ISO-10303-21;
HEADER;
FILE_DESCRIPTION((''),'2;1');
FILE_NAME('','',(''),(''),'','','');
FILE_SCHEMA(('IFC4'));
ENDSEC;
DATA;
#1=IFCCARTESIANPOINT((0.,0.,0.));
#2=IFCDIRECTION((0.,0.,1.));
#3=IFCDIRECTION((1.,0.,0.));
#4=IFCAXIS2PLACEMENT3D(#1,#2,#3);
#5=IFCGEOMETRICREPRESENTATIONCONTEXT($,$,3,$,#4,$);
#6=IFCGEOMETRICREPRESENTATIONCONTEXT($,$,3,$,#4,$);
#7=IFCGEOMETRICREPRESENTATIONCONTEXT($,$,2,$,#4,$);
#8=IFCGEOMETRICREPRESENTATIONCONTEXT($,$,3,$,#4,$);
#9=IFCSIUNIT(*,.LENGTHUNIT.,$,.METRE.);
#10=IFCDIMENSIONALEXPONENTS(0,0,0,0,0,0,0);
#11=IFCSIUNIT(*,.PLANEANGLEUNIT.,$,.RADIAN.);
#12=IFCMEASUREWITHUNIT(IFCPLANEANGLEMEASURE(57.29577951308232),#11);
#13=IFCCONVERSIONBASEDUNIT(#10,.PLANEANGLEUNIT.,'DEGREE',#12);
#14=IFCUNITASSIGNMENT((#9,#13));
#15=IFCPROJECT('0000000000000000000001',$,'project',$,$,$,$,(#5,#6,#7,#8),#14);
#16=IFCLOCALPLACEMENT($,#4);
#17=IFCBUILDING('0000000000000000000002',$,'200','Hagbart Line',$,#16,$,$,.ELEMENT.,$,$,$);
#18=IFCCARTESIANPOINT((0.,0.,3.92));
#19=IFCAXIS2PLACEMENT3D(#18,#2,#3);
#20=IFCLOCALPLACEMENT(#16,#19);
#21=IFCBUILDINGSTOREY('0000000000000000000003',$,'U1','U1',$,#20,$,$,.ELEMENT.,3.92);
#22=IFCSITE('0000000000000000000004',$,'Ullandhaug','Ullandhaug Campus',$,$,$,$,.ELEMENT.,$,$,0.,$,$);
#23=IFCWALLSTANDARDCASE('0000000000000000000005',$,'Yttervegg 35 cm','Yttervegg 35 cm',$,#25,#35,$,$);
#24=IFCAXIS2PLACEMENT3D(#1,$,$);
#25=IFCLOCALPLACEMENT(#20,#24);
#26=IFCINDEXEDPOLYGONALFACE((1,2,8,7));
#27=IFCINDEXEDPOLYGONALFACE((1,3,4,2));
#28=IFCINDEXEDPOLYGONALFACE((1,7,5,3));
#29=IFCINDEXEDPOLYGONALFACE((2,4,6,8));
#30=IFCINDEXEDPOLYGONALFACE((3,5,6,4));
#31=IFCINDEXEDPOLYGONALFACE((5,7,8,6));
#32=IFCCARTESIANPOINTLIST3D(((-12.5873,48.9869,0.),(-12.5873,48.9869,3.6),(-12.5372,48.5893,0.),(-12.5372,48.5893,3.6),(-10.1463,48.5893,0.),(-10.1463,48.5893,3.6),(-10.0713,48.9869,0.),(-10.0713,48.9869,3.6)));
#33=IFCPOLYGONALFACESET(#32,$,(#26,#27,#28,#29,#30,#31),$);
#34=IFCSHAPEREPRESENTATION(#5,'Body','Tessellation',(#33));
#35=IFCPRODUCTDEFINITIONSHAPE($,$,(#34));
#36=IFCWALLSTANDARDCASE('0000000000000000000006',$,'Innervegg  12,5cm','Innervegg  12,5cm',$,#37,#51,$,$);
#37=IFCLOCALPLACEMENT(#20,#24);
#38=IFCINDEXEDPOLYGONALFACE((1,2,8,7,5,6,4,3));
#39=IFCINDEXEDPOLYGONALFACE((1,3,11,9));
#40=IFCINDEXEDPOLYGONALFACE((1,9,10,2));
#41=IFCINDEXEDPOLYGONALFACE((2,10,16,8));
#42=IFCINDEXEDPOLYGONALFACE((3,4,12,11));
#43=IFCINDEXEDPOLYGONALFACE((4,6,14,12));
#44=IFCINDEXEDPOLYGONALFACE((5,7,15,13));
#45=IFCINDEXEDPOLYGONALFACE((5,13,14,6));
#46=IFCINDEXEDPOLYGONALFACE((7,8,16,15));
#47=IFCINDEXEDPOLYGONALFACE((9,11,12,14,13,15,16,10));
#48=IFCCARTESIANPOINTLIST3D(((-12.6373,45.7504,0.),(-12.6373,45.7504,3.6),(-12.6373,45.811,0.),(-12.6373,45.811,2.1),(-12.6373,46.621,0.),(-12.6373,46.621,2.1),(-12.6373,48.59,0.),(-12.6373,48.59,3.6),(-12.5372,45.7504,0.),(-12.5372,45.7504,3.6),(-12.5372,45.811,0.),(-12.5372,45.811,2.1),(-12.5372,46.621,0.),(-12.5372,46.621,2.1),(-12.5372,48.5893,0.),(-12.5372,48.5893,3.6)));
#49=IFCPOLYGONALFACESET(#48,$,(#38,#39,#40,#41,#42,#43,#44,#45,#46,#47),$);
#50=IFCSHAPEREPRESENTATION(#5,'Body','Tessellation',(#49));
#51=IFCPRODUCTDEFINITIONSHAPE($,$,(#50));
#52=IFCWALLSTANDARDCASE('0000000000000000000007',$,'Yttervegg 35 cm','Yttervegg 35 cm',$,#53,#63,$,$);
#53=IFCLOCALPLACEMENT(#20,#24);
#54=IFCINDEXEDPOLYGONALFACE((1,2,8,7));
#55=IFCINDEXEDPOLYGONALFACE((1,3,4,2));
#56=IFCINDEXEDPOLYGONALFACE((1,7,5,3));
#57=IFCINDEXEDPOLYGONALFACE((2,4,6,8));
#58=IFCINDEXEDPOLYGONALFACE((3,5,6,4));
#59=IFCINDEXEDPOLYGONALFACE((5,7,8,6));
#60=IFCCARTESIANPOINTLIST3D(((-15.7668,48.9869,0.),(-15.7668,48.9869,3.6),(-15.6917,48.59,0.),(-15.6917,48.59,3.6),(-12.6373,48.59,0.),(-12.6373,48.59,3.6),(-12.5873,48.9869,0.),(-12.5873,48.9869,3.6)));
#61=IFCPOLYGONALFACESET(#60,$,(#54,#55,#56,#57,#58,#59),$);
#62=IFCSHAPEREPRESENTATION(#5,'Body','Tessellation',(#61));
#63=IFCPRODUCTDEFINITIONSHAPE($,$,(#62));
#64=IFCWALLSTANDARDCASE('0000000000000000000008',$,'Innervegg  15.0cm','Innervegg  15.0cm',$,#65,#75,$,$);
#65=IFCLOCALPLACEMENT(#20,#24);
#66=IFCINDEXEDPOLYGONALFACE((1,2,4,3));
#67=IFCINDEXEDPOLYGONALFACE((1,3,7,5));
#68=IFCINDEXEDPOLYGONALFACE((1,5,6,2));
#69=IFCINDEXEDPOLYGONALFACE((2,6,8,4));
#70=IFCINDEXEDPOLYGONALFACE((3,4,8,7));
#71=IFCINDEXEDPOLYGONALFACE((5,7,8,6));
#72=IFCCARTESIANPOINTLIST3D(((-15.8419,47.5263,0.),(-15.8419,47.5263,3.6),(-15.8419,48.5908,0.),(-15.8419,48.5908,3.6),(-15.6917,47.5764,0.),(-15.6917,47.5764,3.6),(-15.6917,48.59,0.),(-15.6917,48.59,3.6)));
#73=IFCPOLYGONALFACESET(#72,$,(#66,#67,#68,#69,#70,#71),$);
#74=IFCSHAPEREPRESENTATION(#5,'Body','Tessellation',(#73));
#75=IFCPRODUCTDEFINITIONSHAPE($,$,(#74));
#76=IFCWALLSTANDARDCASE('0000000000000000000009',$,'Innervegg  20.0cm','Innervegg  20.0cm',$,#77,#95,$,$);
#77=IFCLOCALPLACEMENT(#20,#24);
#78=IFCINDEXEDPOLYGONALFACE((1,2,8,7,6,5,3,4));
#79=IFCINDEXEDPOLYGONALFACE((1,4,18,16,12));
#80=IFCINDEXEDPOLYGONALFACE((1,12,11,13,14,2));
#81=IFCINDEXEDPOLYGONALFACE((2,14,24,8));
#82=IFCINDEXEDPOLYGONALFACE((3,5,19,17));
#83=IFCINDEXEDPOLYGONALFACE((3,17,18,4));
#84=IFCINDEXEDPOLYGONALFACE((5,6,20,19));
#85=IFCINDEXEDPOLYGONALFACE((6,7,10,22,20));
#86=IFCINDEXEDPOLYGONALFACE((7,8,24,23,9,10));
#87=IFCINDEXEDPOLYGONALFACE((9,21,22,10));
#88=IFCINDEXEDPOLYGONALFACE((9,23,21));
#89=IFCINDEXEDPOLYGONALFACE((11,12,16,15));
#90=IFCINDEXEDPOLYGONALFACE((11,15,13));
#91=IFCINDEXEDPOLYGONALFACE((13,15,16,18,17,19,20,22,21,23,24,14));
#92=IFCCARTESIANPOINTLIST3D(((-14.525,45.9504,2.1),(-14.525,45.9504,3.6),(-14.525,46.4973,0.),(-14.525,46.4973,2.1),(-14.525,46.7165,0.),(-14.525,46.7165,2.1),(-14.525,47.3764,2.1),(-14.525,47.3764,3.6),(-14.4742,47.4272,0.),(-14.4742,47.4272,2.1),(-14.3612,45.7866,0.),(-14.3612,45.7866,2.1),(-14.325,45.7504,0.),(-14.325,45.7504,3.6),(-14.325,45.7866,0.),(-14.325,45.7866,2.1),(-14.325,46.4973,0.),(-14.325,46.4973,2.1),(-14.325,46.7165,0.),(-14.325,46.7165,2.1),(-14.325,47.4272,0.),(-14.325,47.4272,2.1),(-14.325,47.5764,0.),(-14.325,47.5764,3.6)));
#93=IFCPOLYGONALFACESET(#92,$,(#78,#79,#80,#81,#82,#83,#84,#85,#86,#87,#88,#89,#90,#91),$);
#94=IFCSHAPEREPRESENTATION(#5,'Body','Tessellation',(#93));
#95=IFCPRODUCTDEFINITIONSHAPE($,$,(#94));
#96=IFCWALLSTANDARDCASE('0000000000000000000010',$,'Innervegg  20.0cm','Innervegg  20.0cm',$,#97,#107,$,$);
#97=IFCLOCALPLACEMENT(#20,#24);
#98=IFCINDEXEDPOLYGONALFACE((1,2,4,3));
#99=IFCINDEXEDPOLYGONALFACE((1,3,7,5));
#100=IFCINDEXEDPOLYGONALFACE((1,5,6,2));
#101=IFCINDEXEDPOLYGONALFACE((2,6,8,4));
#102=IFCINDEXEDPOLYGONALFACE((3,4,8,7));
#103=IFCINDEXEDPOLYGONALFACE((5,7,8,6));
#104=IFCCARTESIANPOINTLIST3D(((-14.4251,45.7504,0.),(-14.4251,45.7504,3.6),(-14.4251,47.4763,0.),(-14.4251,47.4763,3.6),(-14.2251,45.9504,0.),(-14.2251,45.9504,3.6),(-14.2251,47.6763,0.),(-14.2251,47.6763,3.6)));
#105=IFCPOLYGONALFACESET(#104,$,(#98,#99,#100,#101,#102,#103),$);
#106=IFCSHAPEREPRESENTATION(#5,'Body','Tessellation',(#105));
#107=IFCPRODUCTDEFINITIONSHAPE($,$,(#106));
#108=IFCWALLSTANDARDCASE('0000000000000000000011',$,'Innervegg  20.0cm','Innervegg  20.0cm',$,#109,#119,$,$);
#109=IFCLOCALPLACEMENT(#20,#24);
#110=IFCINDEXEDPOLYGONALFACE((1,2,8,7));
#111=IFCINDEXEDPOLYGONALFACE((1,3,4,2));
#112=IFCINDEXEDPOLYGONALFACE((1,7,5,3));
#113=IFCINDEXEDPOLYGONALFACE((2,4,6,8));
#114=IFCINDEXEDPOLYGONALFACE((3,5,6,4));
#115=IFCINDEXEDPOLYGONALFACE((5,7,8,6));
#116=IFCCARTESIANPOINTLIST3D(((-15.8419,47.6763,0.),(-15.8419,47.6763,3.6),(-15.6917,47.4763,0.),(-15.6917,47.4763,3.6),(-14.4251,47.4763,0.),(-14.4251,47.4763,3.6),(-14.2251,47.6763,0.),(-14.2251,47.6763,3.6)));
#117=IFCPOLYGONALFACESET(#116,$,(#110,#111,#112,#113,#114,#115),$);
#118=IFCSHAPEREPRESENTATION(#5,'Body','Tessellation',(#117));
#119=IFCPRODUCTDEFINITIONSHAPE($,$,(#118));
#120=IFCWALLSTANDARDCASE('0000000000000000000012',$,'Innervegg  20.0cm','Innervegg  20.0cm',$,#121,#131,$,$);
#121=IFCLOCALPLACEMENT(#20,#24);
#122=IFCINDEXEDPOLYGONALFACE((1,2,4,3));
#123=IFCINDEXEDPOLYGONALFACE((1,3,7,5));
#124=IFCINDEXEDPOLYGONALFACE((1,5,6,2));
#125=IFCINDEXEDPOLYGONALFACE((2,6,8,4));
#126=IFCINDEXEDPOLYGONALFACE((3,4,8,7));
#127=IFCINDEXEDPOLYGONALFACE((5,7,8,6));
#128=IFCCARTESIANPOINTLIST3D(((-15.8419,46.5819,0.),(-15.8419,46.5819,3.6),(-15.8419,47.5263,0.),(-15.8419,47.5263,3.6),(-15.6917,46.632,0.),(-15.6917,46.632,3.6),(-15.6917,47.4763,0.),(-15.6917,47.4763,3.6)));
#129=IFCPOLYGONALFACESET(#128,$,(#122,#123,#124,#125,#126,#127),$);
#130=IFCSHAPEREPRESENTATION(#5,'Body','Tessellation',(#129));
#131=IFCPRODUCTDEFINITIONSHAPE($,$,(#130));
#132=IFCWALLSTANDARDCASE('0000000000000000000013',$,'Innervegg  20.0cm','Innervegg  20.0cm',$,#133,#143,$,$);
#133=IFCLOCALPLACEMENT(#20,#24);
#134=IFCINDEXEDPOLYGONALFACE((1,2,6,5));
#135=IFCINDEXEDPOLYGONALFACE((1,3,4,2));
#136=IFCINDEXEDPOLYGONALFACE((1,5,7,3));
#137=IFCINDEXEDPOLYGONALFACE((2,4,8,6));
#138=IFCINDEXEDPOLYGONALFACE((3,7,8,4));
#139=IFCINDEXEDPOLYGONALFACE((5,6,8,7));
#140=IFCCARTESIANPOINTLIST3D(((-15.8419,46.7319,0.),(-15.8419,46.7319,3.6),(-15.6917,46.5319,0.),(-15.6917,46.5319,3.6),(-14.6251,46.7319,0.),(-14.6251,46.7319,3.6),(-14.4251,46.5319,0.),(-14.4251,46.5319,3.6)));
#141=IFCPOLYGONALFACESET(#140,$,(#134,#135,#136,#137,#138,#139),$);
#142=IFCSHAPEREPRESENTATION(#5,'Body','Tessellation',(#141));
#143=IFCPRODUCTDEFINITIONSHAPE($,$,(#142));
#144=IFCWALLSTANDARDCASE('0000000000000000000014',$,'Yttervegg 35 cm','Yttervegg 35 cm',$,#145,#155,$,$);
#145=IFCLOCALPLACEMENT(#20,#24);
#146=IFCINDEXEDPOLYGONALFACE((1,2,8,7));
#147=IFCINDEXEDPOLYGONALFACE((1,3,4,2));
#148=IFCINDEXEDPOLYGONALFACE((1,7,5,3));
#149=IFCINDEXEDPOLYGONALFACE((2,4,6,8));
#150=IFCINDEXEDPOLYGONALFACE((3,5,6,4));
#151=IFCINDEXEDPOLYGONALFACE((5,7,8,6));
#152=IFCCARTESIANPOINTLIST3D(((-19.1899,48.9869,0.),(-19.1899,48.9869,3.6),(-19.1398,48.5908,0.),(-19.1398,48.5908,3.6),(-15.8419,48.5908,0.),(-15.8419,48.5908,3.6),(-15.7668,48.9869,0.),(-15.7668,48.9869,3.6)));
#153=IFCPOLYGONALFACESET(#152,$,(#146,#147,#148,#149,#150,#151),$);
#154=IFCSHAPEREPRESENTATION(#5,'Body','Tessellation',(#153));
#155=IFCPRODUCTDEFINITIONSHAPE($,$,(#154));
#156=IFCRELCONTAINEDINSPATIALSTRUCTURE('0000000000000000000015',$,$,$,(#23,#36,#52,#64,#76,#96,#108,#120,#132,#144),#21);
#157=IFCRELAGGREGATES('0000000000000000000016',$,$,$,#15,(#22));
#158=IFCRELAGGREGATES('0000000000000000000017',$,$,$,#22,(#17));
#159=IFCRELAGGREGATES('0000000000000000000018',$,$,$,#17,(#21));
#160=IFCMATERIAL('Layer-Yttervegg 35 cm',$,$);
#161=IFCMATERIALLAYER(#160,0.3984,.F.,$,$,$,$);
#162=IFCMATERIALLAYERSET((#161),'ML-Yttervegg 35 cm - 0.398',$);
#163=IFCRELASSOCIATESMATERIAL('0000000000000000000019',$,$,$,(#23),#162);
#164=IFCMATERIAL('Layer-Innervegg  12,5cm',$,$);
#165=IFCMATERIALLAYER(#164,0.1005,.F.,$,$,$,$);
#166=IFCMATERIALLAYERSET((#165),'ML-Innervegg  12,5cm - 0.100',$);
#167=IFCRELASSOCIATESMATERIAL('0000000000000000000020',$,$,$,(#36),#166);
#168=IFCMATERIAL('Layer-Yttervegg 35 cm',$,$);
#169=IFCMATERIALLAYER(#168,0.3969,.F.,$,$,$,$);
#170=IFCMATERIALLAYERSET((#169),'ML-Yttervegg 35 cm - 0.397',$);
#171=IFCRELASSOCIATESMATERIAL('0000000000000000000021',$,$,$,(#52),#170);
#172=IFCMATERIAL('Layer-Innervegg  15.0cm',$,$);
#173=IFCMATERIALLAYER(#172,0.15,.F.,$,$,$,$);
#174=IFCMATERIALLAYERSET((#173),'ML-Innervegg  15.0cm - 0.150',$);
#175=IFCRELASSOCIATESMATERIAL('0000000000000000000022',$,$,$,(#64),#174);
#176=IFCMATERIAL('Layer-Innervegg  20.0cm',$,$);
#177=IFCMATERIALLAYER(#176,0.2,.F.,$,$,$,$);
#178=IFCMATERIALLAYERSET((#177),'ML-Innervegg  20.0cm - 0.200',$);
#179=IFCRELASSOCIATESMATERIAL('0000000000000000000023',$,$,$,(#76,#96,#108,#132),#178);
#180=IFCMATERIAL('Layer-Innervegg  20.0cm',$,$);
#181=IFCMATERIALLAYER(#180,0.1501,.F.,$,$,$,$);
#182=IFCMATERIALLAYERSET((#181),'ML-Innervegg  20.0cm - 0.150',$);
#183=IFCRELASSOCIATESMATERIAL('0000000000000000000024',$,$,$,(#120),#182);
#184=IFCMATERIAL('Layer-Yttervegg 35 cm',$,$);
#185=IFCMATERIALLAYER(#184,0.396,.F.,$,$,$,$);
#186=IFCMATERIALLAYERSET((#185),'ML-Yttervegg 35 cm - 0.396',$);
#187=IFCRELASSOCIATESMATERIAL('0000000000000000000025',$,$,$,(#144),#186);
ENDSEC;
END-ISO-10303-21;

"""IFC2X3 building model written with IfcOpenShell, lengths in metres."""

from ifc_helpers import new_model, entity, si_unit, converted_unit, frame, origin_with_axes, place, context, project, spatial, polyline, outline, extrude, material, layer, layer_set, layer_usage, element, save


model = new_model("IFC2X3")

# Units and contexts
context_of_model_1 = context(None, 3, world=origin_with_axes())
context_of_model_2 = context(None, 3, world=origin_with_axes())
context_of_model_3 = context(None, 2, world=origin_with_axes())
context_of_model_4 = context(None, 3, world=origin_with_axes())
ifc_project = project(units=[si_unit("LENGTHUNIT", "METRE"), converted_unit("PLANEANGLEUNIT", "DEGREE", entity("IfcPlaneAngleMeasure", 57.29577951308232), si_unit("PLANEANGLEUNIT", "RADIAN"), dimensions=[0, 0, 0, 0, 0, 0, 0])], contexts=[context_of_model_1, context_of_model_2, context_of_model_3, context_of_model_4])

# Site, building, storey
site = spatial("IfcSite", under=ifc_project, Name="Ullandhaug", Description="Ullandhaug Campus", CompositionType="ELEMENT", RefElevation=0.0)
building_placement = place(None, origin_with_axes())
building = spatial("IfcBuilding", under=site, at=building_placement, Name="200", Description="Hagbart Line", CompositionType="ELEMENT")
storey_placement = place(building_placement, frame((0.0, 0.0, 3.92), z_axis=(0.0, 0.0, 1.0), x_axis=(1.0, 0.0, 0.0)))
storey = spatial("IfcBuildingStorey", under=building, at=storey_placement, Name="U1", Description="U1", CompositionType="ELEMENT", Elevation=3.92)

# Shared definitions
ifc_material_1 = material(Name="Layer-Innervegg  15.0cm")
ifc_layer_1 = layer(ifc_material_1, 0.15, ventilated=False)
ifc_layer_set_1 = layer_set([ifc_layer_1], Name="ML-Innervegg  15.0cm - 0.150")
ifc_layer_usage_1 = layer_usage(ifc_layer_set_1, "AXIS2", "POSITIVE", 0.0)
ifc_material_2 = material(Name="Layer-Innervegg  20.0cm")
ifc_layer_2 = layer(ifc_material_2, 0.2, ventilated=False)
ifc_layer_set_2 = layer_set([ifc_layer_2], Name="ML-Innervegg  20.0cm - 0.200")
ifc_layer_usage_2 = layer_usage(ifc_layer_set_2, "AXIS2", "POSITIVE", 0.0)

# Wall
ifc_material_3 = material(Name="Layer-Yttervegg 35 cm")
ifc_layer_3 = layer(ifc_material_3, 0.3984, ventilated=False)
ifc_layer_set_3 = layer_set([ifc_layer_3], Name="ML-Yttervegg 35 cm - 0.398")
ifc_layer_usage_3 = layer_usage(ifc_layer_set_3, "AXIS2", "POSITIVE", 0.0)
wall_1_placement = place(storey_placement, frame((-10.0713, 48.9869, 0.0), z_axis=(0.0, 0.0, 1.0), x_axis=(-1.0, 0.0, 0.0)))
element("IfcWallStandardCase", 1, at=wall_1_placement, inside=storey, material=ifc_layer_usage_3, Name="Yttervegg 35 cm", Description="Yttervegg 35 cm", context=context_of_model_1, shape_type="SweptSolid", body=[
    extrude(outline(polyline([(0.0, 0.0), (2.516, 0.0), (2.466, 0.3976), (0.0751, 0.3976), (0.0, 0.0)])), frame((0.0, 0.0, 0.0), z_axis=(0.0, 0.0, 1.0), x_axis=(1.0, 0.0, 0.0)), (0.0, 0.0, 1.0), 3.6),
])

# Wall, opening
ifc_material_4 = material(Name="Layer-Innervegg  12,5cm")
ifc_layer_4 = layer(ifc_material_4, 0.1005, ventilated=False)
ifc_layer_set_4 = layer_set([ifc_layer_4], Name="ML-Innervegg  12,5cm - 0.100")
ifc_layer_usage_4 = layer_usage(ifc_layer_set_4, "AXIS2", "POSITIVE", 0.0)
wall_2_placement = place(storey_placement, frame((-12.6373, 48.59, 0.0), z_axis=(0.0, 0.0, 1.0), x_axis=(0.0, -1.0, 0.0)))
wall_2 = element("IfcWallStandardCase", 2, at=wall_2_placement, inside=storey, material=ifc_layer_usage_4, Name="Innervegg  12,5cm", Description="Innervegg  12,5cm", context=context_of_model_1, shape_type="SweptSolid", body=[
    extrude(outline(polyline([(0.0, 0.0), (2.8395, 0.0), (2.8395, 0.1001), (0.0007, 0.1001), (0.0, 0.0)])), frame((0.0, 0.0, 0.0), z_axis=(0.0, 0.0, 1.0), x_axis=(1.0, 0.0, 0.0)), (0.0, 0.0, 1.0), 3.6),
])
opening_1_placement = place(wall_2_placement, frame((1.969, 0.1001, 0.0), z_axis=(0.0, 0.0, 1.0), x_axis=(1.0, 0.0, 0.0)))
element("IfcOpeningElement", 3, at=opening_1_placement, cuts=wall_2, context=context_of_model_1, shape_type="SweptSolid", body=[
    extrude(outline(polyline([(0.0, 0.0), (2.1, 0.0), (2.1, 0.81), (0.0, 0.81), (0.0, 0.0)])), frame((0.0, 0.0, 0.0), z_axis=(0.0, 1.0, 0.0), x_axis=(0.0, 0.0, 1.0)), (0.0, 0.0, -1.0), 0.1001),
])

# Walls
ifc_material_5 = material(Name="Layer-Yttervegg 35 cm")
ifc_layer_5 = layer(ifc_material_5, 0.3969, ventilated=False)
ifc_layer_set_5 = layer_set([ifc_layer_5], Name="ML-Yttervegg 35 cm - 0.397")
ifc_layer_usage_5 = layer_usage(ifc_layer_set_5, "AXIS2", "POSITIVE", 0.0)
wall_3_placement = place(storey_placement, frame((-12.5873, 48.9869, 0.0), z_axis=(0.0, 0.0, 1.0), x_axis=(-1.0, 0.0, 0.0)))
element("IfcWallStandardCase", 4, at=wall_3_placement, inside=storey, material=ifc_layer_usage_5, Name="Yttervegg 35 cm", Description="Yttervegg 35 cm", context=context_of_model_1, shape_type="SweptSolid", body=[
    extrude(outline(polyline([(0.0, 0.0), (3.1795, 0.0), (3.1044, 0.3969), (0.05, 0.3969), (0.0, 0.0)])), frame((0.0, 0.0, 0.0), z_axis=(0.0, 0.0, 1.0), x_axis=(1.0, 0.0, 0.0)), (0.0, 0.0, 1.0), 3.6),
])
wall_4_placement = place(storey_placement, frame((-15.8419, 48.5908, 0.0), z_axis=(0.0, 0.0, 1.0), x_axis=(0.0, -1.0, 0.0)))
element("IfcWallStandardCase", 5, at=wall_4_placement, inside=storey, material=ifc_layer_usage_1, Name="Innervegg  15.0cm", Description="Innervegg  15.0cm", context=context_of_model_1, shape_type="SweptSolid", body=[
    extrude(outline(polyline([(0.0, 0.0), (1.0645, 0.0), (1.0144, 0.1501), (0.0009, 0.1501), (0.0, 0.0)])), frame((0.0, 0.0, 0.0), z_axis=(0.0, 0.0, 1.0), x_axis=(1.0, 0.0, 0.0)), (0.0, 0.0, 1.0), 3.6),
])

# Wall, openings
wall_5_placement = place(storey_placement, frame((-14.525, 47.3764, 0.0), z_axis=(0.0, 0.0, 1.0), x_axis=(0.0, -1.0, 0.0)))
wall_5 = element("IfcWallStandardCase", 6, at=wall_5_placement, inside=storey, material=ifc_layer_usage_2, Name="Innervegg  20.0cm", Description="Innervegg  20.0cm", context=context_of_model_1, shape_type="SweptSolid", body=[
    extrude(outline(polyline([(0.0, 0.0), (1.426, 0.0), (1.626, 0.2), (-0.2, 0.2), (0.0, 0.0)])), frame((0.0, 0.0, 0.0), z_axis=(0.0, 0.0, 1.0), x_axis=(1.0, 0.0, 0.0)), (0.0, 0.0, 1.0), 3.6),
])
opening_2_placement = place(wall_5_placement, frame((-0.0509, 0.2, 0.0), z_axis=(0.0, 0.0, 1.0), x_axis=(1.0, 0.0, 0.0)))
element("IfcOpeningElement", 7, at=opening_2_placement, cuts=wall_5, context=context_of_model_1, shape_type="SweptSolid", body=[
    extrude(outline(polyline([(0.0, 0.0), (2.1, 0.0), (2.1, 0.7107), (0.0, 0.7107), (0.0, 0.0)])), frame((0.0, 0.0, 0.0), z_axis=(0.0, 1.0, 0.0), x_axis=(0.0, 0.0, 1.0)), (0.0, 0.0, -1.0), 0.2),
])
opening_3_placement = place(wall_5_placement, frame((0.8791, 0.2, 0.0), z_axis=(0.0, 0.0, 1.0), x_axis=(1.0, 0.0, 0.0)))
element("IfcOpeningElement", 8, at=opening_3_placement, cuts=wall_5, context=context_of_model_1, shape_type="SweptSolid", body=[
    extrude(outline(polyline([(0.0, 0.0), (2.1, 0.0), (2.1, 0.7107), (0.0, 0.7107), (0.0, 0.0)])), frame((0.0, 0.0, 0.0), z_axis=(0.0, 1.0, 0.0), x_axis=(0.0, 0.0, 1.0)), (0.0, 0.0, -1.0), 0.2),
])

# Walls
wall_6_placement = place(storey_placement, frame((-14.2251, 45.9504, 0.0), z_axis=(0.0, 0.0, 1.0), x_axis=(0.0, 1.0, 0.0)))
element("IfcWallStandardCase", 9, at=wall_6_placement, inside=storey, material=ifc_layer_usage_2, Name="Innervegg  20.0cm", Description="Innervegg  20.0cm", context=context_of_model_1, shape_type="SweptSolid", body=[
    extrude(outline(polyline([(0.0, 0.0), (1.7259, 0.0), (1.5259, 0.2), (-0.2, 0.2), (0.0, 0.0)])), frame((0.0, 0.0, 0.0), z_axis=(0.0, 0.0, 1.0), x_axis=(1.0, 0.0, 0.0)), (0.0, 0.0, 1.0), 3.6),
])
wall_7_placement = place(storey_placement, frame((-14.2251, 47.6763, 0.0), z_axis=(0.0, 0.0, 1.0), x_axis=(-1.0, 0.0, 0.0)))
element("IfcWallStandardCase", 10, at=wall_7_placement, inside=storey, material=ifc_layer_usage_2, Name="Innervegg  20.0cm", Description="Innervegg  20.0cm", context=context_of_model_1, shape_type="SweptSolid", body=[
    extrude(outline(polyline([(0.0, 0.0), (1.6168, 0.0), (1.4666, 0.2), (0.2, 0.2), (0.0, 0.0)])), frame((0.0, 0.0, 0.0), z_axis=(0.0, 0.0, 1.0), x_axis=(1.0, 0.0, 0.0)), (0.0, 0.0, 1.0), 3.6),
])
ifc_material_6 = material(Name="Layer-Innervegg  20.0cm")
ifc_layer_6 = layer(ifc_material_6, 0.1501, ventilated=False)
ifc_layer_set_6 = layer_set([ifc_layer_6], Name="ML-Innervegg  20.0cm - 0.150")
ifc_layer_usage_6 = layer_usage(ifc_layer_set_6, "AXIS2", "POSITIVE", 0.0)
wall_8_placement = place(storey_placement, frame((-15.8419, 47.5263, 0.0), z_axis=(0.0, 0.0, 1.0), x_axis=(0.0, -1.0, 0.0)))
element("IfcWallStandardCase", 11, at=wall_8_placement, inside=storey, material=ifc_layer_usage_6, Name="Innervegg  20.0cm", Description="Innervegg  20.0cm", context=context_of_model_1, shape_type="SweptSolid", body=[
    extrude(outline(polyline([(0.0, 0.0), (0.9444, 0.0), (0.8943, 0.1501), (0.05, 0.1501), (0.0, 0.0)])), frame((0.0, 0.0, 0.0), z_axis=(0.0, 0.0, 1.0), x_axis=(1.0, 0.0, 0.0)), (0.0, 0.0, 1.0), 3.6),
])
wall_9_placement = place(storey_placement, frame((-14.6251, 46.7319, 0.0), z_axis=(0.0, 0.0, 1.0), x_axis=(-1.0, 0.0, 0.0)))
element("IfcWallStandardCase", 12, at=wall_9_placement, inside=storey, material=ifc_layer_usage_2, Name="Innervegg  20.0cm", Description="Innervegg  20.0cm", context=context_of_model_1, shape_type="SweptSolid", body=[
    extrude(outline(polyline([(0.0, 0.0), (1.2168, 0.0), (1.0666, 0.2), (-0.2, 0.2), (0.0, 0.0)])), frame((0.0, 0.0, 0.0), z_axis=(0.0, 0.0, 1.0), x_axis=(1.0, 0.0, 0.0)), (0.0, 0.0, 1.0), 3.6),
])
ifc_material_7 = material(Name="Layer-Yttervegg 35 cm")
ifc_layer_7 = layer(ifc_material_7, 0.396, ventilated=False)
ifc_layer_set_7 = layer_set([ifc_layer_7], Name="ML-Yttervegg 35 cm - 0.396")
ifc_layer_usage_7 = layer_usage(ifc_layer_set_7, "AXIS2", "POSITIVE", 0.0)
wall_10_placement = place(storey_placement, frame((-15.7668, 48.9869, 0.0), z_axis=(0.0, 0.0, 1.0), x_axis=(-1.0, 0.0, 0.0)))
element("IfcWallStandardCase", 13, at=wall_10_placement, inside=storey, material=ifc_layer_usage_7, Name="Yttervegg 35 cm", Description="Yttervegg 35 cm", context=context_of_model_1, shape_type="SweptSolid", body=[
    extrude(outline(polyline([(0.0, 0.0), (3.4231, 0.0), (3.373, 0.396), (0.0751, 0.396), (0.0, 0.0)])), frame((0.0, 0.0, 0.0), z_axis=(0.0, 0.0, 1.0), x_axis=(1.0, 0.0, 0.0)), (0.0, 0.0, 1.0), 3.6),
])

save(model, "model.ifc")
